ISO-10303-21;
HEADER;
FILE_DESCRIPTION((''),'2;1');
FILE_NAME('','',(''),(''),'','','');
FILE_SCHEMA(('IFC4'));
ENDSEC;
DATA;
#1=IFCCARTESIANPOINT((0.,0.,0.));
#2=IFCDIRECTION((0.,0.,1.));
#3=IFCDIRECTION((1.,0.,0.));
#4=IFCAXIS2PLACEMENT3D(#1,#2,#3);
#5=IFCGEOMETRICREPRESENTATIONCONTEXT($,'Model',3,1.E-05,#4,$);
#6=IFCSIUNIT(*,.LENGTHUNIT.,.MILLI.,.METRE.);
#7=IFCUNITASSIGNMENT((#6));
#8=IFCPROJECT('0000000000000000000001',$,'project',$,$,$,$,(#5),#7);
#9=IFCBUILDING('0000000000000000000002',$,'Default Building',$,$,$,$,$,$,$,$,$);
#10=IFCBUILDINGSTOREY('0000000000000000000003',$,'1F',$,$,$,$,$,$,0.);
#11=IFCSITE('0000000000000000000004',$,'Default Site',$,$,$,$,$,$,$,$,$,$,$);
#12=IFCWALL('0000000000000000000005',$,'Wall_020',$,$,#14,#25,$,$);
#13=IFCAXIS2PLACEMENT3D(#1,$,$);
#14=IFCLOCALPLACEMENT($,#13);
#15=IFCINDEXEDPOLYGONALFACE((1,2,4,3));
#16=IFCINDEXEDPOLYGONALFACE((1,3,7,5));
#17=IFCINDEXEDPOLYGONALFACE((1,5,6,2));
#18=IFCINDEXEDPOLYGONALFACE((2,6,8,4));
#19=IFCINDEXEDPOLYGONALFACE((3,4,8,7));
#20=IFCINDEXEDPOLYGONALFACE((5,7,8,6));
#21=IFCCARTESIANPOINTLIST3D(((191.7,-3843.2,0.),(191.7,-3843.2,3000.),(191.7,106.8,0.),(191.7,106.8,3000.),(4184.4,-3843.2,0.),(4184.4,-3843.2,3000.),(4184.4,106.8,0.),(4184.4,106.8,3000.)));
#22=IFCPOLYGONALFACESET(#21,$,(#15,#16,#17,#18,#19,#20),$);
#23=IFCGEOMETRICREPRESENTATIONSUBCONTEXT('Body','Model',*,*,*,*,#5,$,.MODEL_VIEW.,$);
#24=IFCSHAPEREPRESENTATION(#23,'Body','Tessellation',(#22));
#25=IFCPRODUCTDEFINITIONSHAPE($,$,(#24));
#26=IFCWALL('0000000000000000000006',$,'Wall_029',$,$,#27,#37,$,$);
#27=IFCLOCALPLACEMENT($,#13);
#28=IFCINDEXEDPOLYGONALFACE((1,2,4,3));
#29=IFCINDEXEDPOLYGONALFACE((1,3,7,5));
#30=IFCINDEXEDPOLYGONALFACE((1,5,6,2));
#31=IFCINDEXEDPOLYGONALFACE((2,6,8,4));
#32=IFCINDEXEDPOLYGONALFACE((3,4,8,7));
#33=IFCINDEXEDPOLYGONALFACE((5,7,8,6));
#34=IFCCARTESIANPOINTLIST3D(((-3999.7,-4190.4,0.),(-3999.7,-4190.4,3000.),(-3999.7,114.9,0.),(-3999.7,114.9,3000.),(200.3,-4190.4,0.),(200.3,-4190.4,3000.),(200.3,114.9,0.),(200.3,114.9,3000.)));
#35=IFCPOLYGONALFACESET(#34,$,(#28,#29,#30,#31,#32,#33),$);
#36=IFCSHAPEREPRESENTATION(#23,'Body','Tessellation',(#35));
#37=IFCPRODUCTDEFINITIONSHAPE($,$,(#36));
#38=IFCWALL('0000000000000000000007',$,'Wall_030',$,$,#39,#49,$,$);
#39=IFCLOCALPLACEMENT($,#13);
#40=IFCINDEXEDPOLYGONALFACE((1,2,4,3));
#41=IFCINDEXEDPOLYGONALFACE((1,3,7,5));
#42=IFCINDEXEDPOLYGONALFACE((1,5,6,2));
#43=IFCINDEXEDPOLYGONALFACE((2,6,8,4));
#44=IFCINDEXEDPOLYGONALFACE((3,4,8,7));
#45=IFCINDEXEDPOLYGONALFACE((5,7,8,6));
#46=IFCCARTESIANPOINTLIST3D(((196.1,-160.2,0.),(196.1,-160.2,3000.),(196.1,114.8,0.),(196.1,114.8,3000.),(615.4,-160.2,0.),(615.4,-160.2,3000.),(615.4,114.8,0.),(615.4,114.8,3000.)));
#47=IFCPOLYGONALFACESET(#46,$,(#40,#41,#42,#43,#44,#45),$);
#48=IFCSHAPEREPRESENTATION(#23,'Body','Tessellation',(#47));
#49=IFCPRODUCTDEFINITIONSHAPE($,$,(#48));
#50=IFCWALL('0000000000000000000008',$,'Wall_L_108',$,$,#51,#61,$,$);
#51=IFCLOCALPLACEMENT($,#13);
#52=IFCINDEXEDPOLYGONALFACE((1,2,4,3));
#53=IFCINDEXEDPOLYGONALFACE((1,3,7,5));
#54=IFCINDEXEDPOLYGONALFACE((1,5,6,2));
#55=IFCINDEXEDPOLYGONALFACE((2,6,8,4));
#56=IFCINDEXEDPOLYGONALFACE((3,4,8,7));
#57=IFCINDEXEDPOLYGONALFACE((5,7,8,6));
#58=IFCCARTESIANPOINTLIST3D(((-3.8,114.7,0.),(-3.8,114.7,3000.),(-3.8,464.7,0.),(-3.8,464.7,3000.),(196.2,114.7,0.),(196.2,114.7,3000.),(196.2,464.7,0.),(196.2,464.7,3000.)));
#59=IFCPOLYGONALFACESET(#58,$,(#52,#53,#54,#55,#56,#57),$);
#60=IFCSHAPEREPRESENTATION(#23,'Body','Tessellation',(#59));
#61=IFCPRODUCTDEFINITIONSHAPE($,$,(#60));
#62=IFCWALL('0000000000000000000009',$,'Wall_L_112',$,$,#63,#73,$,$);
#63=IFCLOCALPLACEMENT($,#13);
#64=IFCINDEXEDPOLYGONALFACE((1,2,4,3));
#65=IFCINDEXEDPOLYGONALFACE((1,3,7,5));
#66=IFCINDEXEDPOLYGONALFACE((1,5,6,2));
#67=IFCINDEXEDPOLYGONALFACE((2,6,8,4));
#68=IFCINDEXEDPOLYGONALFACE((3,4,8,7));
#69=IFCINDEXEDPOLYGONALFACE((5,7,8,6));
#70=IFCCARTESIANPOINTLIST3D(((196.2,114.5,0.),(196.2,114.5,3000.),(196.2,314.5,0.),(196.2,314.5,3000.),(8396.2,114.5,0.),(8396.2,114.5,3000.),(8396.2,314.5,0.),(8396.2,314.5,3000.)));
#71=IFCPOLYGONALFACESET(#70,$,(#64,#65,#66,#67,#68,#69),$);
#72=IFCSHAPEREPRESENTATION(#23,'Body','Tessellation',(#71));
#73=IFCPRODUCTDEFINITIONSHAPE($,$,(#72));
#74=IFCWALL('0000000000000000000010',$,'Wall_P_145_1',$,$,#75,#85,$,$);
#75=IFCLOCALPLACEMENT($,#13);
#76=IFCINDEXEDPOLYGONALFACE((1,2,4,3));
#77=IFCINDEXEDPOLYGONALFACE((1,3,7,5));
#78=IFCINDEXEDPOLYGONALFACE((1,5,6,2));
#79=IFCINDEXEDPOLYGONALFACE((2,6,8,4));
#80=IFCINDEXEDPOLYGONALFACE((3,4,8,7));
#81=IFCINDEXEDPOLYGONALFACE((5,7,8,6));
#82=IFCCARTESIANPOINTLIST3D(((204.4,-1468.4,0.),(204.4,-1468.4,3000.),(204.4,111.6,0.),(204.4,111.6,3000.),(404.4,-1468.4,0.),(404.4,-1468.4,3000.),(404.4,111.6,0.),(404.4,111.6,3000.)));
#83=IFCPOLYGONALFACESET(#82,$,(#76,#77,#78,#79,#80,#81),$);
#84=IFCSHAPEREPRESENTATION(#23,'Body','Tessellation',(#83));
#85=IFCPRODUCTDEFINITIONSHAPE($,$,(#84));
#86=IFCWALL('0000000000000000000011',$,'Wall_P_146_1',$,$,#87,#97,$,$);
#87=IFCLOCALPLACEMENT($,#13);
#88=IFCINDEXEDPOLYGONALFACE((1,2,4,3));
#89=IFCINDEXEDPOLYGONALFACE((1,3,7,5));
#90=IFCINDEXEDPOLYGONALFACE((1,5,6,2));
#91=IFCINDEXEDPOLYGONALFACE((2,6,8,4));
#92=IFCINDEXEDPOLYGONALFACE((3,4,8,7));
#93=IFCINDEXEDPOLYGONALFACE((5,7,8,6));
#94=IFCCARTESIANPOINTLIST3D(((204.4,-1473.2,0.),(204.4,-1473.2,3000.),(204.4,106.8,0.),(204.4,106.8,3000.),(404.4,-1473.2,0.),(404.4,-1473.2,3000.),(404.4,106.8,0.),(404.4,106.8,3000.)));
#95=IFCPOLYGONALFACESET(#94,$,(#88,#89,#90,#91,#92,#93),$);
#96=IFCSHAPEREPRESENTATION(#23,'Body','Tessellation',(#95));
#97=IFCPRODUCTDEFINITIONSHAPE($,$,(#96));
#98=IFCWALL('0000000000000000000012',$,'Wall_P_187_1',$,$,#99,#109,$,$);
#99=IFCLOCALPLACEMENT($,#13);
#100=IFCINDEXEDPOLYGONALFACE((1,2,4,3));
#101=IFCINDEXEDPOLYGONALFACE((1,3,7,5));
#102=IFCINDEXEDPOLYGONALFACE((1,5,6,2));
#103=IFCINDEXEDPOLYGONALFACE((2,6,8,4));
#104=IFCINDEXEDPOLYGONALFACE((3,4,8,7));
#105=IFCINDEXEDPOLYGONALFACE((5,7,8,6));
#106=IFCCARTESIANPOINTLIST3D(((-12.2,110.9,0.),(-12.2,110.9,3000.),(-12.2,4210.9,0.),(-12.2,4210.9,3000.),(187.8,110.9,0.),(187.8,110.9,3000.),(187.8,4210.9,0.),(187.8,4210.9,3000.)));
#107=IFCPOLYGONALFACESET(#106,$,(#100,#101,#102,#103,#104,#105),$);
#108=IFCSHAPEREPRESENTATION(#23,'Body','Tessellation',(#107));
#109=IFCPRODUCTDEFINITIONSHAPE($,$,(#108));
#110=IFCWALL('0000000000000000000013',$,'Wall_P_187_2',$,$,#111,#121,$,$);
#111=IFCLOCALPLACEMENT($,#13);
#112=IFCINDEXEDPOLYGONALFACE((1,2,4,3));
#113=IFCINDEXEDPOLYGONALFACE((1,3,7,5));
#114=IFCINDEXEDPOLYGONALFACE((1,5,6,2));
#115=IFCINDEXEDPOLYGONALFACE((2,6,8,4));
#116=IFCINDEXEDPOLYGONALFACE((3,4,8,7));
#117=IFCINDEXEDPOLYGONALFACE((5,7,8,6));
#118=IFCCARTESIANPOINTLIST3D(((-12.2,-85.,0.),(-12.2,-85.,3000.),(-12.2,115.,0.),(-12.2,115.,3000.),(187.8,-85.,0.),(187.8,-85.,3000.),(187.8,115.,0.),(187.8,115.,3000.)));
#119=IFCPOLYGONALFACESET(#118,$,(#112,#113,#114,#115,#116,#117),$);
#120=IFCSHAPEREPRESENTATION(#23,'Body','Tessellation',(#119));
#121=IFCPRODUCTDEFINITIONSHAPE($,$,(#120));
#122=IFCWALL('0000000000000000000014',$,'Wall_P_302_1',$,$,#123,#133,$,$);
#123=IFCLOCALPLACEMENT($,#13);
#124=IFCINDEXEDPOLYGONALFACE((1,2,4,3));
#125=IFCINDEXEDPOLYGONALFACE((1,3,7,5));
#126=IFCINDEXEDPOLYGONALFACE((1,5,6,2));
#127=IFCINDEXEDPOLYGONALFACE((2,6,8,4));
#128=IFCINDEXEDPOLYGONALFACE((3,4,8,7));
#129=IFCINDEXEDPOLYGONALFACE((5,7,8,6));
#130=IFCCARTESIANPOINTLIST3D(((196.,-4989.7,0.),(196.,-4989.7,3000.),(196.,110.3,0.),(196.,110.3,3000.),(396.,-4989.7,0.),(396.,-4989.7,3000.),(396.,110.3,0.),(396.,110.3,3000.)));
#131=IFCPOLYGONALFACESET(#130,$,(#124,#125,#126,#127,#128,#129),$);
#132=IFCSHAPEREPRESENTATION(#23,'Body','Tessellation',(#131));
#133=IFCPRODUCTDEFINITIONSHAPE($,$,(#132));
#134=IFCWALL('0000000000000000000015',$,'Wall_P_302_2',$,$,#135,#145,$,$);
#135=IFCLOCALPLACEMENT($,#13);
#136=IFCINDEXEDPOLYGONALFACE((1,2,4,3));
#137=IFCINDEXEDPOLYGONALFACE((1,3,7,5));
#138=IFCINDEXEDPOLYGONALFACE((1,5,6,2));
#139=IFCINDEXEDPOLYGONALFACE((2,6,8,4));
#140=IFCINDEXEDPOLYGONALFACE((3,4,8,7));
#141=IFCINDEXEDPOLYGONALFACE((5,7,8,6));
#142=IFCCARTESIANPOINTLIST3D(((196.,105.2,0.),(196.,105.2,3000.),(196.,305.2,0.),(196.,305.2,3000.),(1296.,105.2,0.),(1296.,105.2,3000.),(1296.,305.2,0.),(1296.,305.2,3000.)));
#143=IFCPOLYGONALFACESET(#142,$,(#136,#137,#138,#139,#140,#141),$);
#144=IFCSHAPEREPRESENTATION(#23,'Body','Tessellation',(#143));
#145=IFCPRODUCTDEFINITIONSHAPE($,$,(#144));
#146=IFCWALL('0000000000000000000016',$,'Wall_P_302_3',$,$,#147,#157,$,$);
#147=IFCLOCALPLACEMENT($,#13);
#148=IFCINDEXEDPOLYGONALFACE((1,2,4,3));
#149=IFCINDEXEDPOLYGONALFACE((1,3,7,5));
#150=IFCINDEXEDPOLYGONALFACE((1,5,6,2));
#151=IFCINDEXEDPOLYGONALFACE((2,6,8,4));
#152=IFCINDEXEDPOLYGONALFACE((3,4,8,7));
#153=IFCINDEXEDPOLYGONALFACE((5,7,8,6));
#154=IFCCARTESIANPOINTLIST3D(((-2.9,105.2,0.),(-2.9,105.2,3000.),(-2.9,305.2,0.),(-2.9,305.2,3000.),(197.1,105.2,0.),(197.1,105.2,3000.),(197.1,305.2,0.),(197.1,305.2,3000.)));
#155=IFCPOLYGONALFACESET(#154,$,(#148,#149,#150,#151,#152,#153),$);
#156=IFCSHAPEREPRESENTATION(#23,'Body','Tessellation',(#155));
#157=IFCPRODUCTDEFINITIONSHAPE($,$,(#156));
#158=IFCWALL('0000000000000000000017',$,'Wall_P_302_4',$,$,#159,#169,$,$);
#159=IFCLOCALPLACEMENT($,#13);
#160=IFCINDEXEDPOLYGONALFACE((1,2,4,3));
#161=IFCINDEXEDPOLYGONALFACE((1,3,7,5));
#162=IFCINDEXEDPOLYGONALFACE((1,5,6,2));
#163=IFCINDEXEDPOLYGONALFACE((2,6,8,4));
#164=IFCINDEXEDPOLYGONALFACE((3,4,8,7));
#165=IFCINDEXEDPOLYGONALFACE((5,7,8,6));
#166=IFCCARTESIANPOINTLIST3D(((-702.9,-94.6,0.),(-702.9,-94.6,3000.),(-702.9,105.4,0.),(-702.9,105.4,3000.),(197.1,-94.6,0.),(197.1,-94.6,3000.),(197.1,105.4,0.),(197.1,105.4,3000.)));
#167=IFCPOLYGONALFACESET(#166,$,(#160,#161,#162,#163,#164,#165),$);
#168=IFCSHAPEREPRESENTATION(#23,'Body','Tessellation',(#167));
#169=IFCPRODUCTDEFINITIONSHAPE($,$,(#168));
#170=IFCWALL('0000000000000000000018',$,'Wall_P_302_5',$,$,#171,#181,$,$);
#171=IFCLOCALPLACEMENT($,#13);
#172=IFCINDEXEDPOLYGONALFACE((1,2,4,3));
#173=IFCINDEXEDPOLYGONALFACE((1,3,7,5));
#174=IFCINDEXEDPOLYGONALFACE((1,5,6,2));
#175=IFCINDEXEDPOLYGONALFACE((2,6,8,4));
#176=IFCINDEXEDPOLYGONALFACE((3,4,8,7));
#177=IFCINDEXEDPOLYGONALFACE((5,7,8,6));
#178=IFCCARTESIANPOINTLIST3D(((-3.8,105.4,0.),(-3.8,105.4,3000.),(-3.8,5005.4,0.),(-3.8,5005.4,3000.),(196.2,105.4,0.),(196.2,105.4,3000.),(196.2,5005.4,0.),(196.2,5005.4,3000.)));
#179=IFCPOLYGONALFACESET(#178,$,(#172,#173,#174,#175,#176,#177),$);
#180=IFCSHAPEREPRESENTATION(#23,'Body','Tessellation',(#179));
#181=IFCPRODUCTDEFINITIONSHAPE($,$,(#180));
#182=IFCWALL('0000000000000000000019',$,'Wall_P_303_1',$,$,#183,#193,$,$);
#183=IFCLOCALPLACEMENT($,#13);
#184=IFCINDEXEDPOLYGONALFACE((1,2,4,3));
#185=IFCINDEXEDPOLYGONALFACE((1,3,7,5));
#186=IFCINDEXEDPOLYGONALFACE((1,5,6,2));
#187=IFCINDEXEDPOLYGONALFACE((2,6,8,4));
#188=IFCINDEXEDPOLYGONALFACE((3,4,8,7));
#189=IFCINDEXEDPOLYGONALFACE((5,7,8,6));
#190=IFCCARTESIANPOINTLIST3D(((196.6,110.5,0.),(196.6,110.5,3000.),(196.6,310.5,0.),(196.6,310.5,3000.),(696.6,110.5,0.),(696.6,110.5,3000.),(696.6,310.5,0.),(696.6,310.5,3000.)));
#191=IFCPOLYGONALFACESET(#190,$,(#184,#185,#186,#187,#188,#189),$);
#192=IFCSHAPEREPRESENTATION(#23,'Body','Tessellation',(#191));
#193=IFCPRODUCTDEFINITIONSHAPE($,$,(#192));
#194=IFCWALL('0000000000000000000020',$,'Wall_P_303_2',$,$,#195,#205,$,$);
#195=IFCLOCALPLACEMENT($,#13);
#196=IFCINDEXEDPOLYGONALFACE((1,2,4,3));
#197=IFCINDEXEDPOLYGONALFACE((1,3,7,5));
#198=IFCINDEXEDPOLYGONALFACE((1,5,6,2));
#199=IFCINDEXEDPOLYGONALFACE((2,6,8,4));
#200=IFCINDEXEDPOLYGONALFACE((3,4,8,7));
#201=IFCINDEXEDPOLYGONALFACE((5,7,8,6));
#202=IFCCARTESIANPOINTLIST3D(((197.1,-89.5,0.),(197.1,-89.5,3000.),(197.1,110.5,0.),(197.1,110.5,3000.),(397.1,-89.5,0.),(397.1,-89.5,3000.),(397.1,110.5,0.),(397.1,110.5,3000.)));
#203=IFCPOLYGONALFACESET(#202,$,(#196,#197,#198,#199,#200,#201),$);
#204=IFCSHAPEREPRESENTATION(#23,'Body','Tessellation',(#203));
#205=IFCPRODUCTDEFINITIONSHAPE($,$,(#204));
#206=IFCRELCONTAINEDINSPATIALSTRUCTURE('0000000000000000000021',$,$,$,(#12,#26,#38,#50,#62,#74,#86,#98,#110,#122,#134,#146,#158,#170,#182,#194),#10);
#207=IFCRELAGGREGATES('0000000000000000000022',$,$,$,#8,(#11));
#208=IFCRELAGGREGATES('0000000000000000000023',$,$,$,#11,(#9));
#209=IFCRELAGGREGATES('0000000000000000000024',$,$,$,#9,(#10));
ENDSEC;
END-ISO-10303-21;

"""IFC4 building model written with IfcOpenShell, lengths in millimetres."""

from ifc_helpers import new_model, si_unit, frame, origin_with_axes, place, context, subcontext, project, spatial, indexed_curve, outline, extrude, element, save


model = new_model("IFC4")

# Units and contexts
model_context = context("Model", 3, precision=1e-05, world=origin_with_axes())
body_context = subcontext(model_context, "Body", "Model", "MODEL_VIEW")
ifc_project = project(units=[si_unit("LENGTHUNIT", "METRE", prefix="MILLI")], contexts=[model_context])

# Site, building, storey
site = spatial("IfcSite", under=ifc_project, Name="Default Site")
building = spatial("IfcBuilding", under=site, Name="Default Building")
storey = spatial("IfcBuildingStorey", under=building, Name="1F", Elevation=0.0)

# Walls
wall_1_placement = place(None, frame((191.7, 106.8, 0.0), z_axis=(0.0, 0.0, 1.0), x_axis=(0.0, -1.0, 0.0)))
element("IfcWall", 1, at=wall_1_placement, inside=storey, Name="Wall_020", context=body_context, shape_type="SweptSolid", body=[
    extrude(outline(indexed_curve([(0.0, 0.0), (0.0, 3992.7), (3950.0, 3992.7), (3950.0, 0.0), (0.0, 0.0)], self_intersect=False)), origin_with_axes(), (0.0, 0.0, 1.0), 3000.0),
])
wall_2_placement = place(None, frame((200.3, 114.9, 0.0), z_axis=(0.0, 0.0, 1.0), x_axis=(-1.0, 0.0, 0.0)))
element("IfcWall", 2, at=wall_2_placement, inside=storey, Name="Wall_029", context=body_context, shape_type="SweptSolid", body=[
    extrude(outline(indexed_curve([(0.0, 0.0), (0.0, 4305.3), (4200.0, 4305.3), (4200.0, 0.0), (0.0, 0.0)], self_intersect=False)), origin_with_axes(), (0.0, 0.0, 1.0), 3000.0),
])
wall_3_placement = place(None, frame((196.1, 114.8, 0.0), z_axis=(0.0, 0.0, 1.0), x_axis=(0.0, -1.0, 0.0)))
element("IfcWall", 3, at=wall_3_placement, inside=storey, Name="Wall_030", context=body_context, shape_type="SweptSolid", body=[
    extrude(outline(indexed_curve([(0.0, 0.0), (0.0, 419.3), (275.0, 419.3), (275.0, 0.0), (0.0, 0.0)], self_intersect=False)), origin_with_axes(), (0.0, 0.0, 1.0), 3000.0),
])
wall_4_placement = place(None, frame((196.2, 114.7, 0.0), z_axis=(0.0, 0.0, 1.0), x_axis=(0.0, 1.0, 0.0)))
element("IfcWall", 4, at=wall_4_placement, inside=storey, Name="Wall_L_108", context=body_context, shape_type="SweptSolid", body=[
    extrude(outline(indexed_curve([(0.0, 0.0), (0.0, 200.0), (350.0, 200.0), (350.0, 0.0), (0.0, 0.0)], self_intersect=False)), origin_with_axes(), (0.0, 0.0, 1.0), 3000.0),
])
wall_5_placement = place(None, frame((196.2, 114.5, 0.0), z_axis=(0.0, 0.0, 1.0), x_axis=(1.0, 0.0, 0.0)))
element("IfcWall", 5, at=wall_5_placement, inside=storey, Name="Wall_L_112", context=body_context, shape_type="SweptSolid", body=[
    extrude(outline(indexed_curve([(0.0, 0.0), (0.0, 200.0), (8200.0, 200.0), (8200.0, 0.0), (0.0, 0.0)], self_intersect=False)), origin_with_axes(), (0.0, 0.0, 1.0), 3000.0),
])
wall_6_placement = place(None, frame((204.4, 111.6, 0.0), z_axis=(0.0, 0.0, 1.0), x_axis=(0.0, -1.0, 0.0)))
element("IfcWall", 6, at=wall_6_placement, inside=storey, Name="Wall_P_145_1", context=body_context, shape_type="SweptSolid", body=[
    extrude(outline(indexed_curve([(0.0, 0.0), (0.0, 200.0), (1580.0, 200.0), (1580.0, 0.0), (0.0, 0.0)], self_intersect=False)), origin_with_axes(), (0.0, 0.0, 1.0), 3000.0),
])
wall_7_placement = place(None, frame((204.4, 106.8, 0.0), z_axis=(0.0, 0.0, 1.0), x_axis=(0.0, -1.0, 0.0)))
element("IfcWall", 7, at=wall_7_placement, inside=storey, Name="Wall_P_146_1", context=body_context, shape_type="SweptSolid", body=[
    extrude(outline(indexed_curve([(0.0, 0.0), (0.0, 200.0), (1580.0, 200.0), (1580.0, 0.0), (0.0, 0.0)], self_intersect=False)), origin_with_axes(), (0.0, 0.0, 1.0), 3000.0),
])
wall_8_placement = place(None, frame((187.8, 110.9, 0.0), z_axis=(0.0, 0.0, 1.0), x_axis=(0.0, 1.0, 0.0)))
element("IfcWall", 8, at=wall_8_placement, inside=storey, Name="Wall_P_187_1", context=body_context, shape_type="SweptSolid", body=[
    extrude(outline(indexed_curve([(0.0, 0.0), (0.0, 200.0), (4100.0, 200.0), (4100.0, 0.0), (0.0, 0.0)], self_intersect=False)), origin_with_axes(), (0.0, 0.0, 1.0), 3000.0),
])
wall_9_placement = place(None, frame((187.8, 115.0, 0.0), z_axis=(0.0, 0.0, 1.0), x_axis=(-1.0, 0.0, 0.0)))
element("IfcWall", 9, at=wall_9_placement, inside=storey, Name="Wall_P_187_2", context=body_context, shape_type="SweptSolid", body=[
    extrude(outline(indexed_curve([(0.0, 0.0), (0.0, 200.0), (200.0, 200.0), (200.0, 0.0), (0.0, 0.0)], self_intersect=False)), origin_with_axes(), (0.0, 0.0, 1.0), 3000.0),
])
wall_10_placement = place(None, frame((196.0, 110.3, 0.0), z_axis=(0.0, 0.0, 1.0), x_axis=(0.0, -1.0, 0.0)))
element("IfcWall", 10, at=wall_10_placement, inside=storey, Name="Wall_P_302_1", context=body_context, shape_type="SweptSolid", body=[
    extrude(outline(indexed_curve([(0.0, 0.0), (0.0, 200.0), (5100.0, 200.0), (5100.0, 0.0), (0.0, 0.0)], self_intersect=False)), origin_with_axes(), (0.0, 0.0, 1.0), 3000.0),
])
wall_11_placement = place(None, frame((196.0, 105.2, 0.0), z_axis=(0.0, 0.0, 1.0), x_axis=(1.0, 0.0, 0.0)))
element("IfcWall", 11, at=wall_11_placement, inside=storey, Name="Wall_P_302_2", context=body_context, shape_type="SweptSolid", body=[
    extrude(outline(indexed_curve([(0.0, 0.0), (0.0, 200.0), (1100.0, 200.0), (1100.0, 0.0), (0.0, 0.0)], self_intersect=False)), origin_with_axes(), (0.0, 0.0, 1.0), 3000.0),
])
wall_12_placement = place(None, frame((197.1, 105.2, 0.0), z_axis=(0.0, 0.0, 1.0), x_axis=(0.0, 1.0, 0.0)))
element("IfcWall", 12, at=wall_12_placement, inside=storey, Name="Wall_P_302_3", context=body_context, shape_type="SweptSolid", body=[
    extrude(outline(indexed_curve([(0.0, 0.0), (0.0, 200.0), (200.0, 200.0), (200.0, 0.0), (0.0, 0.0)], self_intersect=False)), origin_with_axes(), (0.0, 0.0, 1.0), 3000.0),
])
wall_13_placement = place(None, frame((197.1, 105.4, 0.0), z_axis=(0.0, 0.0, 1.0), x_axis=(-1.0, 0.0, 0.0)))
element("IfcWall", 13, at=wall_13_placement, inside=storey, Name="Wall_P_302_4", context=body_context, shape_type="SweptSolid", body=[
    extrude(outline(indexed_curve([(0.0, 0.0), (0.0, 200.0), (900.0, 200.0), (900.0, 0.0), (0.0, 0.0)], self_intersect=False)), origin_with_axes(), (0.0, 0.0, 1.0), 3000.0),
])
wall_14_placement = place(None, frame((196.2, 105.4, 0.0), z_axis=(0.0, 0.0, 1.0), x_axis=(0.0, 1.0, 0.0)))
element("IfcWall", 14, at=wall_14_placement, inside=storey, Name="Wall_P_302_5", context=body_context, shape_type="SweptSolid", body=[
    extrude(outline(indexed_curve([(0.0, 0.0), (0.0, 200.0), (4900.0, 200.0), (4900.0, 0.0), (0.0, 0.0)], self_intersect=False)), origin_with_axes(), (0.0, 0.0, 1.0), 3000.0),
])
wall_15_placement = place(None, frame((196.6, 110.5, 0.0), z_axis=(0.0, 0.0, 1.0), x_axis=(1.0, 0.0, 0.0)))
element("IfcWall", 15, at=wall_15_placement, inside=storey, Name="Wall_P_303_1", context=body_context, shape_type="SweptSolid", body=[
    extrude(outline(indexed_curve([(0.0, 0.0), (0.0, 200.0), (500.0, 200.0), (500.0, 0.0), (0.0, 0.0)], self_intersect=False)), origin_with_axes(), (0.0, 0.0, 1.0), 3000.0),
])
wall_16_placement = place(None, frame((197.1, 110.5, 0.0), z_axis=(0.0, 0.0, 1.0), x_axis=(0.0, -1.0, 0.0)))
element("IfcWall", 16, at=wall_16_placement, inside=storey, Name="Wall_P_303_2", context=body_context, shape_type="SweptSolid", body=[
    extrude(outline(indexed_curve([(0.0, 0.0), (0.0, 200.0), (200.0, 200.0), (200.0, 0.0), (0.0, 0.0)], self_intersect=False)), origin_with_axes(), (0.0, 0.0, 1.0), 3000.0),
])

save(model, "model.ifc")
